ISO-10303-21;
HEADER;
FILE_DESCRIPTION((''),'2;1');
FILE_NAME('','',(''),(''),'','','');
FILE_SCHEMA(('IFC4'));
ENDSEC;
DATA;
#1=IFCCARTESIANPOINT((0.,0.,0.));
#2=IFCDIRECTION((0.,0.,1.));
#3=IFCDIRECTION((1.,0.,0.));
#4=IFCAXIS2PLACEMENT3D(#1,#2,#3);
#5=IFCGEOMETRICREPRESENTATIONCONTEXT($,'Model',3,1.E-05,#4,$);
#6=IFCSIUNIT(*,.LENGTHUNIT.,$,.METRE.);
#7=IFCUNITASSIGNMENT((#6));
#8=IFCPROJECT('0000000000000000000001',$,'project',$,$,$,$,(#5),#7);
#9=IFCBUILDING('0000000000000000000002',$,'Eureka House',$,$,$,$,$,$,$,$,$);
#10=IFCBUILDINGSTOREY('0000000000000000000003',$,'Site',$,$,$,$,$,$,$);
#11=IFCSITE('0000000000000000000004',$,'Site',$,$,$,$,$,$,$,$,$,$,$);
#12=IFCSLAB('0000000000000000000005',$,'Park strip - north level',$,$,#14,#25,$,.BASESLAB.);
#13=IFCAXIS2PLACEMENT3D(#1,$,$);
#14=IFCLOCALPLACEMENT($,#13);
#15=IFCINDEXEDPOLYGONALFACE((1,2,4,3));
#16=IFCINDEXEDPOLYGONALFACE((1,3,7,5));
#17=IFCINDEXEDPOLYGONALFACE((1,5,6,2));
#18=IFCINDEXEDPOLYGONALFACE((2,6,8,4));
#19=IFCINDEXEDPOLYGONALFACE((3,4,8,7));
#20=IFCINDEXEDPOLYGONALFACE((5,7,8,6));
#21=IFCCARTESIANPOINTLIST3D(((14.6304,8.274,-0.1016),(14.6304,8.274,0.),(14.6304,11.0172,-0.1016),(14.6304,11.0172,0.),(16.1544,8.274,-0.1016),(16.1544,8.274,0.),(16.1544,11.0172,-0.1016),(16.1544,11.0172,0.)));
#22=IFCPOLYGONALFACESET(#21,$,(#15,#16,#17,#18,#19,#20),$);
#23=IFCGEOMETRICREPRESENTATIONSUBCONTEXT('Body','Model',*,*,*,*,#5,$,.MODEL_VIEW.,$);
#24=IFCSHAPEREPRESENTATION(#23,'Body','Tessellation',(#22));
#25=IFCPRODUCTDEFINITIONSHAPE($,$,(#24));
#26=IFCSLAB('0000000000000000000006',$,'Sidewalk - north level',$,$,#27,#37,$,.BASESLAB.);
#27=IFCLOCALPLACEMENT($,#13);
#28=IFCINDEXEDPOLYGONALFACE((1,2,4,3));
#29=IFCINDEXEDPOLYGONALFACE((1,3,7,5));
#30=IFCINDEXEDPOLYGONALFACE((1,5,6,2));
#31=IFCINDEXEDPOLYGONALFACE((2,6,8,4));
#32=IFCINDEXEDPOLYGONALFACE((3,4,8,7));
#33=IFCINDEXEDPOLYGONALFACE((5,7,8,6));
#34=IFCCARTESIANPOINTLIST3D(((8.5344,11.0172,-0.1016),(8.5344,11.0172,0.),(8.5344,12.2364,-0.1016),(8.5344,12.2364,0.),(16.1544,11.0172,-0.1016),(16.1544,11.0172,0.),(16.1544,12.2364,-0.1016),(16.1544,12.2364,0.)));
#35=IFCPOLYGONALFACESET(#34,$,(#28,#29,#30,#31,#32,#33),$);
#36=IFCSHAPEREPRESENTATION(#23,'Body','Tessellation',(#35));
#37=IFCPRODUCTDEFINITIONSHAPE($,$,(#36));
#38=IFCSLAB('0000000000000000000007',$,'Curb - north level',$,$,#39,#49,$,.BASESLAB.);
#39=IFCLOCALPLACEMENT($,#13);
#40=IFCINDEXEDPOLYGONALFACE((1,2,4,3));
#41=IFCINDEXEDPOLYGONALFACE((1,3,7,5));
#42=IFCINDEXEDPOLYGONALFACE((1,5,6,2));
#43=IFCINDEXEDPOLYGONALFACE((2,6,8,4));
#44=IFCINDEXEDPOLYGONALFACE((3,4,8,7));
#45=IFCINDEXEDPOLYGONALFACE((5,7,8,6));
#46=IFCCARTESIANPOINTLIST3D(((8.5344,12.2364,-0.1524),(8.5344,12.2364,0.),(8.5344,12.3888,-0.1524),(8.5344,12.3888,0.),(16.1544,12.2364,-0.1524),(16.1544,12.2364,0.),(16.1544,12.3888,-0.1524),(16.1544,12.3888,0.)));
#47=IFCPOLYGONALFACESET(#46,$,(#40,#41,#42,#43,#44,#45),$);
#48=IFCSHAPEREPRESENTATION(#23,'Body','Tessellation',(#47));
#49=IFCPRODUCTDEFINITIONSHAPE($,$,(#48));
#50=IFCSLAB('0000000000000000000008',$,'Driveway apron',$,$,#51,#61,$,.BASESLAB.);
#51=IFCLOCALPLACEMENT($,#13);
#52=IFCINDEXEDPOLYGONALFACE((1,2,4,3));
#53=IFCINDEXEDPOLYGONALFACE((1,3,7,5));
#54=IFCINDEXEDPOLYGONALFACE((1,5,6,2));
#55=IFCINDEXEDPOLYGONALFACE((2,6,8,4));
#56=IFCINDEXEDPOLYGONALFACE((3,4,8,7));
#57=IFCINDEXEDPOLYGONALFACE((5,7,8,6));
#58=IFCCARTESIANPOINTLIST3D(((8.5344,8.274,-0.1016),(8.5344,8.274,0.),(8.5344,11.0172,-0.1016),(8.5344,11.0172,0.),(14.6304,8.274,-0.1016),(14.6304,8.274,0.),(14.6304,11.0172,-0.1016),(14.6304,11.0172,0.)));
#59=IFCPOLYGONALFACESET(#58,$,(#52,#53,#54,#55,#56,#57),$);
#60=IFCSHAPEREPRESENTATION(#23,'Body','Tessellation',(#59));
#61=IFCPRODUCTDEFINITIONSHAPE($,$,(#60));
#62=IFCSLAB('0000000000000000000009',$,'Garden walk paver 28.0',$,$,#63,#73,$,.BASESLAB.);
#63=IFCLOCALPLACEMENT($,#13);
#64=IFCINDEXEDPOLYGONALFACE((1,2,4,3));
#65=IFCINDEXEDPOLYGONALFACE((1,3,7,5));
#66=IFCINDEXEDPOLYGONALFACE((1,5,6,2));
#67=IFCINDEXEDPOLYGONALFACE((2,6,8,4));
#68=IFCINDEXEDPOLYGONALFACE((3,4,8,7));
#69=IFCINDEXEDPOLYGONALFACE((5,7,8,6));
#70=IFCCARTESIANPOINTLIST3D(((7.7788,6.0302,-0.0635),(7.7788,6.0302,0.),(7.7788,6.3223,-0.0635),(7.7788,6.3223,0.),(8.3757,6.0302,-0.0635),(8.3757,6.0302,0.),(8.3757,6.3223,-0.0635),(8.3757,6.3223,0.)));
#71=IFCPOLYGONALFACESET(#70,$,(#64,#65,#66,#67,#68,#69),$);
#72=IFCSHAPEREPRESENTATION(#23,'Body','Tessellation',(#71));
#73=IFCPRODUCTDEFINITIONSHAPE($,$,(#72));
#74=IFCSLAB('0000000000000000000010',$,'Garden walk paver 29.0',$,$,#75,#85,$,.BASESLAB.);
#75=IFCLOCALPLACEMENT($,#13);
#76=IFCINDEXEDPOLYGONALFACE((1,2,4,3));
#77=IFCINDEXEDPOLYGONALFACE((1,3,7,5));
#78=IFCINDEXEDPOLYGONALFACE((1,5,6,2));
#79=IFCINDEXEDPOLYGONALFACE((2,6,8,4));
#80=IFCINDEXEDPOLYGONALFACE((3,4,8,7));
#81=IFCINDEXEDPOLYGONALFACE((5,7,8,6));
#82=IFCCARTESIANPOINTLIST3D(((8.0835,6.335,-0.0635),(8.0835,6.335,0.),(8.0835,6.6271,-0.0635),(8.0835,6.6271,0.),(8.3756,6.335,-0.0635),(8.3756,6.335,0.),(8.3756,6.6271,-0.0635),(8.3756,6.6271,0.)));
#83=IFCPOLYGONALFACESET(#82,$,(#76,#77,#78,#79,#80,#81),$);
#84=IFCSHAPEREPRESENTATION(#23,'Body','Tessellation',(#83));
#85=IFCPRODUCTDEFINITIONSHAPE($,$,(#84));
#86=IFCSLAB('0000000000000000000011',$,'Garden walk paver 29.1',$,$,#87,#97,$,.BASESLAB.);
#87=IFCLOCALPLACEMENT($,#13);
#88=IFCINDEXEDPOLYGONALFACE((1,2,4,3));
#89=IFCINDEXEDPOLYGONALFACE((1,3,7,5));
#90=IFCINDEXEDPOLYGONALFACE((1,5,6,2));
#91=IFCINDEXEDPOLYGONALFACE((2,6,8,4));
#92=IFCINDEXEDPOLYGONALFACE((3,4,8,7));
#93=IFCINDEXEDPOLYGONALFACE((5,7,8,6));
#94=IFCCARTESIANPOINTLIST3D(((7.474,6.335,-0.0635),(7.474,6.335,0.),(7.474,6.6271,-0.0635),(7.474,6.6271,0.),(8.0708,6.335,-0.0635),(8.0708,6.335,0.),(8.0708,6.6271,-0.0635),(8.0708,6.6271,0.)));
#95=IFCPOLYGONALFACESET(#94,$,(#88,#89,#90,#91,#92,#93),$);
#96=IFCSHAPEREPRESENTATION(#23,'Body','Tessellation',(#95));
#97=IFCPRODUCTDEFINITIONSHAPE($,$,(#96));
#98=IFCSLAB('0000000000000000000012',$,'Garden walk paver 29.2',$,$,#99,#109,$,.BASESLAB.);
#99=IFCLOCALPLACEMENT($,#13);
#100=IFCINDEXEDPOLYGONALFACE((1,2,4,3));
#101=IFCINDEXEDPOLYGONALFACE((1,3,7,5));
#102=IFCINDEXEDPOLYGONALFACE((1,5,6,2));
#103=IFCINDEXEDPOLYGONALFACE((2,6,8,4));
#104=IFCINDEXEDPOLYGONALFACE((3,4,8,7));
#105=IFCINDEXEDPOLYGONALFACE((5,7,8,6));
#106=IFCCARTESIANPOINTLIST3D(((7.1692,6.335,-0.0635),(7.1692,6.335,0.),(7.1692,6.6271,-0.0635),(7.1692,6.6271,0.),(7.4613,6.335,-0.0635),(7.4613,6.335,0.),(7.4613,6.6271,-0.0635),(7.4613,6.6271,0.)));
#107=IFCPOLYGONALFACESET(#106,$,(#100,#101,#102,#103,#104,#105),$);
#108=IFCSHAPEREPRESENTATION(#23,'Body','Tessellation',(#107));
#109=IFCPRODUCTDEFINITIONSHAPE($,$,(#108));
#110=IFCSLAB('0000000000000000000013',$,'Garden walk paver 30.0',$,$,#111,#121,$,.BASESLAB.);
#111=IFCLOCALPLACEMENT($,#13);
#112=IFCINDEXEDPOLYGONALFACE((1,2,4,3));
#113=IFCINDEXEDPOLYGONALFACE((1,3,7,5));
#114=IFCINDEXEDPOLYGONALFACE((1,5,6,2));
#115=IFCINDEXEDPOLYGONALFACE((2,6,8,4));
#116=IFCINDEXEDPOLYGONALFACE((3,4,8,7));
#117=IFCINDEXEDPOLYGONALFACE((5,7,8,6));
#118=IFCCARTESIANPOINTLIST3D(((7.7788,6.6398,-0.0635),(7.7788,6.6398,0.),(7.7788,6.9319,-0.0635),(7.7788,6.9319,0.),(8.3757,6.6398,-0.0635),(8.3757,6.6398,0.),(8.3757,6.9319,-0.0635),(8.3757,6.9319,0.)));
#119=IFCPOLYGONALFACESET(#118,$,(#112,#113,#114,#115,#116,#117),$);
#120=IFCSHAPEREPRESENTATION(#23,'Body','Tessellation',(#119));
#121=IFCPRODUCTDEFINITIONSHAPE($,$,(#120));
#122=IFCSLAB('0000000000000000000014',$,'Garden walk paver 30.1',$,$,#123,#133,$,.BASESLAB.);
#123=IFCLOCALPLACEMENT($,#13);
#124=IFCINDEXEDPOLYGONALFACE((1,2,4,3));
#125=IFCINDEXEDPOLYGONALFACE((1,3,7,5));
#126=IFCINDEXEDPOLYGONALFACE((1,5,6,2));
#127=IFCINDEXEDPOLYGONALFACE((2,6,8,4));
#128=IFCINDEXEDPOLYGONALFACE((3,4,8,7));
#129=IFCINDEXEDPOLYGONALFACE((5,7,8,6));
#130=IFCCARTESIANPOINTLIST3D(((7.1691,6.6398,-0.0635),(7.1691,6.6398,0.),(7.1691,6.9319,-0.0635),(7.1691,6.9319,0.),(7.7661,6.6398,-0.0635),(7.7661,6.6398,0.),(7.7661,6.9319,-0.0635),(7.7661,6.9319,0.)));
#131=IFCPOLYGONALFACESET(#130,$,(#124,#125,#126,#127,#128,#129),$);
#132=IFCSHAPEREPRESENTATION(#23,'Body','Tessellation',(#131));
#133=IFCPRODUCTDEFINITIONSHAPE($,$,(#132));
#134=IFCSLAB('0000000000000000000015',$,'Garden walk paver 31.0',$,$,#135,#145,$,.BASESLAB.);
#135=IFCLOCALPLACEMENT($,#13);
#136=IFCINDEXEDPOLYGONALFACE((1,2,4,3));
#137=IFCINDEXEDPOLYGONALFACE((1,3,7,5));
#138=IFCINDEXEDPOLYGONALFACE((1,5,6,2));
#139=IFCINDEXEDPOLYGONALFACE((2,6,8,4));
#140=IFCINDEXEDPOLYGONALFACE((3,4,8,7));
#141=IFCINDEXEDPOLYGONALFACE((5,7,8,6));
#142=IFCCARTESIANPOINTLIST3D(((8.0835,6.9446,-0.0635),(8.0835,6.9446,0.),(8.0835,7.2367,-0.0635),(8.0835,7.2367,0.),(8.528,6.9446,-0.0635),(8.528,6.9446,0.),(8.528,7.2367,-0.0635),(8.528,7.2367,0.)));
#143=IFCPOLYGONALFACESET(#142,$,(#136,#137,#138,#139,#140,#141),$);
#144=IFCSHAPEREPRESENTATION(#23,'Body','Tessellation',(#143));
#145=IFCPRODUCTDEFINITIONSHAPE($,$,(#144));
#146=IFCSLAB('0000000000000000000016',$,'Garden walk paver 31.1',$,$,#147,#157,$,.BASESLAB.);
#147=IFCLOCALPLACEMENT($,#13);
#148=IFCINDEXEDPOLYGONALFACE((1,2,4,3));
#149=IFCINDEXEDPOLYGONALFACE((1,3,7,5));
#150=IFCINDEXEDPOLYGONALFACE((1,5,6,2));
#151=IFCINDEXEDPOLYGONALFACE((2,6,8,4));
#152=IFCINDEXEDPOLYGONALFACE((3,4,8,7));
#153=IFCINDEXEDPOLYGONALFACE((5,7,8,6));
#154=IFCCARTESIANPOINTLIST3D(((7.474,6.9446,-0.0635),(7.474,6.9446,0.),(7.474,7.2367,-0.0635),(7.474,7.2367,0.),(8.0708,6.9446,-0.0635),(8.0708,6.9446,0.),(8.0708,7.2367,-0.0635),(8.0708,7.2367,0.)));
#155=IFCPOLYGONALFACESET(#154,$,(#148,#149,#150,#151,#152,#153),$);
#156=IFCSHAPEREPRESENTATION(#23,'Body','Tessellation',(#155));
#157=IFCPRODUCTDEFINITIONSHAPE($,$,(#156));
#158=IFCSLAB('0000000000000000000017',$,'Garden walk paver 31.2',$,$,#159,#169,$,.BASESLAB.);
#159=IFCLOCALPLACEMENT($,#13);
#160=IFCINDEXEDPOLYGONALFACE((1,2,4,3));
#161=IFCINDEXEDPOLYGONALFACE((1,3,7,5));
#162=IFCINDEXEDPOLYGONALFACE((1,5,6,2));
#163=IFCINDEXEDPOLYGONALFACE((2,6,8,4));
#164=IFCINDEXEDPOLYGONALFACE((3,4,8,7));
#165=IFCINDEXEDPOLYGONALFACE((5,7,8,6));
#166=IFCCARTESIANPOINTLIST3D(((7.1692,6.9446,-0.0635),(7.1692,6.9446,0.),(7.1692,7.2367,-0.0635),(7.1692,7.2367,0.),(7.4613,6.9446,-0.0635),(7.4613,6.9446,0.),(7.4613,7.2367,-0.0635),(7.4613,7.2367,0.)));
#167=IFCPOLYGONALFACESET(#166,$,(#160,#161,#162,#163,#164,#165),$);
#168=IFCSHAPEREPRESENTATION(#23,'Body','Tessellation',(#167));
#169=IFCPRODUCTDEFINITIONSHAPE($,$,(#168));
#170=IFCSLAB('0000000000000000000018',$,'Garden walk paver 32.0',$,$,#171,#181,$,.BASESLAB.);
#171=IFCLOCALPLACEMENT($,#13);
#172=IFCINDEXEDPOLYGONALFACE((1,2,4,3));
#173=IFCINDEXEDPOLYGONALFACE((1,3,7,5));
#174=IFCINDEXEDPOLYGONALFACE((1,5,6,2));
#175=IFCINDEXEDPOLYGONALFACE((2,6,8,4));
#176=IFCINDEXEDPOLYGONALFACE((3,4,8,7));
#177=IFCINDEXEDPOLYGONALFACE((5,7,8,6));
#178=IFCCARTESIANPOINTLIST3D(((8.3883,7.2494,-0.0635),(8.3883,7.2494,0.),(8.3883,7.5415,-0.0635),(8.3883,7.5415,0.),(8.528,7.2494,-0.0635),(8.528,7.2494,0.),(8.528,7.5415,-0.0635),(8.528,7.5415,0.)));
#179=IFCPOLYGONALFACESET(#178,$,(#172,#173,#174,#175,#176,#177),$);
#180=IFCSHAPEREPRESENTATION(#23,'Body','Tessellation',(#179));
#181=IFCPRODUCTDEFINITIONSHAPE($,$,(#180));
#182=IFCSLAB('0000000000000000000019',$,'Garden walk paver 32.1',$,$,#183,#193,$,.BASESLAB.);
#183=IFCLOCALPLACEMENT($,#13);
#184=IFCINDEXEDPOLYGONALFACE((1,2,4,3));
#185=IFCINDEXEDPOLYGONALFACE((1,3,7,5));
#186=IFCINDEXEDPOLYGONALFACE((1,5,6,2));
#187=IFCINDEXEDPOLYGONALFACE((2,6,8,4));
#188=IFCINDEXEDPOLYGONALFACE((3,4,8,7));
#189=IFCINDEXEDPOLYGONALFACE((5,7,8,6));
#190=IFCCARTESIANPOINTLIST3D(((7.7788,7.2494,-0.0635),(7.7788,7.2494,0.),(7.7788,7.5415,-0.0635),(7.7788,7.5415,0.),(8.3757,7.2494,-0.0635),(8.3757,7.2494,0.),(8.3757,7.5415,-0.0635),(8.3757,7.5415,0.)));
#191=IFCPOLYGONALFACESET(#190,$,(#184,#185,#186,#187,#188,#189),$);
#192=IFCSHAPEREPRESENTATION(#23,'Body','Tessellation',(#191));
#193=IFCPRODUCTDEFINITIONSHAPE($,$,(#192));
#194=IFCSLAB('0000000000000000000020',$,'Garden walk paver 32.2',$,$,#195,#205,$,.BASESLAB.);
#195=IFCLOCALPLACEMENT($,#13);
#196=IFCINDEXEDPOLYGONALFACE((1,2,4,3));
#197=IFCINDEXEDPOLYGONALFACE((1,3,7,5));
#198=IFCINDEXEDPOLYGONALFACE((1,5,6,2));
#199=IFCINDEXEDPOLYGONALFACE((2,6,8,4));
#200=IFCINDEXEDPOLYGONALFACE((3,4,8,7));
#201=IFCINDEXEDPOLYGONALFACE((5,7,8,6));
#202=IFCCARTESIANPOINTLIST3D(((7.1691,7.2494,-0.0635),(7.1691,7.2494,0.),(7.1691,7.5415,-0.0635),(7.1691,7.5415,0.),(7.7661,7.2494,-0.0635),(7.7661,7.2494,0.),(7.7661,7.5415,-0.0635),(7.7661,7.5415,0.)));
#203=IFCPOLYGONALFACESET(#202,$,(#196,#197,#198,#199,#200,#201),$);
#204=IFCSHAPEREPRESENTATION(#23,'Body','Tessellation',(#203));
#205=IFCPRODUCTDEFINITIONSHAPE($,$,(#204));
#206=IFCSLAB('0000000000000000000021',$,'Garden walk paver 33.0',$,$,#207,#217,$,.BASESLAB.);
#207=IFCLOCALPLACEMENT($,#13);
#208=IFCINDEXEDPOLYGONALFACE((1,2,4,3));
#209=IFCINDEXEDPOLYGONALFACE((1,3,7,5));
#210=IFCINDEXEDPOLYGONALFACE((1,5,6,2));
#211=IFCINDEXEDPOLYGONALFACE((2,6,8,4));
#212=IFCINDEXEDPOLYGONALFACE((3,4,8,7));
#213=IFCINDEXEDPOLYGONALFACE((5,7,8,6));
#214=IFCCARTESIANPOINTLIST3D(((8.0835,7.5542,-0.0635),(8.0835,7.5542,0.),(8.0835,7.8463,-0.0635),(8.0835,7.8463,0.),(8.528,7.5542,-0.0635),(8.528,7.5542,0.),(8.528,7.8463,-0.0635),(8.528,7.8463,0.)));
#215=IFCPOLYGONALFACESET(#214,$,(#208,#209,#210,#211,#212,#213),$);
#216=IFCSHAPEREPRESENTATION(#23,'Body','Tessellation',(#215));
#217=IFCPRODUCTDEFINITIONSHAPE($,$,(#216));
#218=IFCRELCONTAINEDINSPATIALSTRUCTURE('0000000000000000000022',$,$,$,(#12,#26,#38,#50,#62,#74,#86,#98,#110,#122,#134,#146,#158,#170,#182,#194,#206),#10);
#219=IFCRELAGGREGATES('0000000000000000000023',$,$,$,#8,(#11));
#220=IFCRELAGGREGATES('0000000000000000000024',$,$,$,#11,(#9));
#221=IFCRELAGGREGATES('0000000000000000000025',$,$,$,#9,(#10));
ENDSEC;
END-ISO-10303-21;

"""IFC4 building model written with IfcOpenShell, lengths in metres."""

from ifc_helpers import new_model, si_unit, frame, origin, origin_with_axes, origin_2d, place, context, subcontext, project, spatial, rectangle, extrude, element, save


model = new_model("IFC4")

# Units and contexts
model_context = context("Model", 3, precision=1e-05, world=origin_with_axes())
body_context = subcontext(model_context, "Body", "Model", "MODEL_VIEW")
ifc_project = project(units=[si_unit("LENGTHUNIT", "METRE")], contexts=[model_context])

# Site, building, storey
site = spatial("IfcSite", under=ifc_project, Name="Site")
building = spatial("IfcBuilding", under=site, Name="Eureka House")
storey = spatial("IfcBuildingStorey", under=building, Name="Site")

# Slabs
slab_1_placement = place(None, frame((15.3924, 9.6456, -0.1016), z_axis=(0.0, 0.0, 1.0), x_axis=(1.0, 0.0, 0.0)))
element("IfcSlab", 1, at=slab_1_placement, inside=storey, Name="Park strip - north level", PredefinedType="BASESLAB", context=body_context, shape_type="SweptSolid", body=[
    extrude(rectangle(XDim=1.524, YDim=2.7432, at=origin_2d()), origin(), (0.0, 0.0, 1.0), 0.1016),
])
slab_2_placement = place(None, frame((12.3444, 11.6268, -0.1016), z_axis=(0.0, 0.0, 1.0), x_axis=(1.0, 0.0, 0.0)))
element("IfcSlab", 2, at=slab_2_placement, inside=storey, Name="Sidewalk - north level", PredefinedType="BASESLAB", context=body_context, shape_type="SweptSolid", body=[
    extrude(rectangle(XDim=7.62, YDim=1.2192, at=origin_2d()), origin(), (0.0, 0.0, 1.0), 0.1016),
])
slab_3_placement = place(None, frame((12.3444, 12.3126, -0.1524), z_axis=(0.0, 0.0, 1.0), x_axis=(1.0, 0.0, 0.0)))
element("IfcSlab", 3, at=slab_3_placement, inside=storey, Name="Curb - north level", PredefinedType="BASESLAB", context=body_context, shape_type="SweptSolid", body=[
    extrude(rectangle(XDim=7.62, YDim=0.1524, at=origin_2d()), origin(), (0.0, 0.0, 1.0), 0.1524),
])
slab_4_placement = place(None, frame((11.5824, 9.6456, -0.1016), z_axis=(0.0, 0.0, 1.0), x_axis=(1.0, 0.0, 0.0)))
element("IfcSlab", 4, at=slab_4_placement, inside=storey, Name="Driveway apron", PredefinedType="BASESLAB", context=body_context, shape_type="SweptSolid", body=[
    extrude(rectangle(XDim=6.096, YDim=2.7432, at=origin_2d()), origin(), (0.0, 0.0, 1.0), 0.1016),
])
slab_5_placement = place(None, frame((8.0772, 6.1763, -0.0635), z_axis=(0.0, 0.0, 1.0), x_axis=(1.0, 0.0, 0.0)))
element("IfcSlab", 5, at=slab_5_placement, inside=storey, Name="Garden walk paver 28.0", PredefinedType="BASESLAB", context=body_context, shape_type="SweptSolid", body=[
    extrude(rectangle(XDim=0.5969, YDim=0.2921, at=origin_2d()), origin(), (0.0, 0.0, 1.0), 0.0635),
])
slab_6_placement = place(None, frame((8.2296, 6.4811, -0.0635), z_axis=(0.0, 0.0, 1.0), x_axis=(1.0, 0.0, 0.0)))
element("IfcSlab", 6, at=slab_6_placement, inside=storey, Name="Garden walk paver 29.0", PredefinedType="BASESLAB", context=body_context, shape_type="SweptSolid", body=[
    extrude(rectangle(XDim=0.2921, YDim=0.2921, at=origin_2d()), origin(), (0.0, 0.0, 1.0), 0.0635),
])
slab_7_placement = place(None, frame((7.7724, 6.4811, -0.0635), z_axis=(0.0, 0.0, 1.0), x_axis=(1.0, 0.0, 0.0)))
element("IfcSlab", 7, at=slab_7_placement, inside=storey, Name="Garden walk paver 29.1", PredefinedType="BASESLAB", context=body_context, shape_type="SweptSolid", body=[
    extrude(rectangle(XDim=0.5969, YDim=0.2921, at=origin_2d()), origin(), (0.0, 0.0, 1.0), 0.0635),
])
slab_8_placement = place(None, frame((7.3152, 6.4811, -0.0635), z_axis=(0.0, 0.0, 1.0), x_axis=(1.0, 0.0, 0.0)))
element("IfcSlab", 8, at=slab_8_placement, inside=storey, Name="Garden walk paver 29.2", PredefinedType="BASESLAB", context=body_context, shape_type="SweptSolid", body=[
    extrude(rectangle(XDim=0.2921, YDim=0.2921, at=origin_2d()), origin(), (0.0, 0.0, 1.0), 0.0635),
])
for number, where, z_axis, x_axis, name in (
    (9, (8.0772, 6.7859, -0.0635), (0.0, 0.0, 1.0), (1.0, 0.0, 0.0), "Garden walk paver 30.0"),
    (10, (7.4676, 6.7859, -0.0635), (0.0, 0.0, 1.0), (1.0, 0.0, 0.0), "Garden walk paver 30.1"),
):
    element("IfcSlab", number, at=place(None, frame(where, z_axis=z_axis, x_axis=x_axis)), inside=storey, Name=name, PredefinedType="BASESLAB", context=body_context, shape_type="SweptSolid", body=[
        extrude(rectangle(XDim=0.5969, YDim=0.2921, at=origin_2d()), origin(), (0.0, 0.0, 1.0), 0.0635),
    ])
slab_9_placement = place(None, frame((8.3058, 7.0907, -0.0635), z_axis=(0.0, 0.0, 1.0), x_axis=(1.0, 0.0, 0.0)))
element("IfcSlab", 11, at=slab_9_placement, inside=storey, Name="Garden walk paver 31.0", PredefinedType="BASESLAB", context=body_context, shape_type="SweptSolid", body=[
    extrude(rectangle(XDim=0.4445, YDim=0.2921, at=origin_2d()), origin(), (0.0, 0.0, 1.0), 0.0635),
])
slab_10_placement = place(None, frame((7.7724, 7.0907, -0.0635), z_axis=(0.0, 0.0, 1.0), x_axis=(1.0, 0.0, 0.0)))
element("IfcSlab", 12, at=slab_10_placement, inside=storey, Name="Garden walk paver 31.1", PredefinedType="BASESLAB", context=body_context, shape_type="SweptSolid", body=[
    extrude(rectangle(XDim=0.5969, YDim=0.2921, at=origin_2d()), origin(), (0.0, 0.0, 1.0), 0.0635),
])
slab_11_placement = place(None, frame((7.3152, 7.0907, -0.0635), z_axis=(0.0, 0.0, 1.0), x_axis=(1.0, 0.0, 0.0)))
element("IfcSlab", 13, at=slab_11_placement, inside=storey, Name="Garden walk paver 31.2", PredefinedType="BASESLAB", context=body_context, shape_type="SweptSolid", body=[
    extrude(rectangle(XDim=0.2921, YDim=0.2921, at=origin_2d()), origin(), (0.0, 0.0, 1.0), 0.0635),
])
slab_12_placement = place(None, frame((8.4582, 7.3955, -0.0635), z_axis=(0.0, 0.0, 1.0), x_axis=(1.0, 0.0, 0.0)))
element("IfcSlab", 14, at=slab_12_placement, inside=storey, Name="Garden walk paver 32.0", PredefinedType="BASESLAB", context=body_context, shape_type="SweptSolid", body=[
    extrude(rectangle(XDim=0.1397, YDim=0.2921, at=origin_2d()), origin(), (0.0, 0.0, 1.0), 0.0635),
])
for number, where, z_axis, x_axis, name in (
    (15, (8.0772, 7.3955, -0.0635), (0.0, 0.0, 1.0), (1.0, 0.0, 0.0), "Garden walk paver 32.1"),
    (16, (7.4676, 7.3955, -0.0635), (0.0, 0.0, 1.0), (1.0, 0.0, 0.0), "Garden walk paver 32.2"),
):
    element("IfcSlab", number, at=place(None, frame(where, z_axis=z_axis, x_axis=x_axis)), inside=storey, Name=name, PredefinedType="BASESLAB", context=body_context, shape_type="SweptSolid", body=[
        extrude(rectangle(XDim=0.5969, YDim=0.2921, at=origin_2d()), origin(), (0.0, 0.0, 1.0), 0.0635),
    ])
slab_13_placement = place(None, frame((8.3058, 7.7003, -0.0635), z_axis=(0.0, 0.0, 1.0), x_axis=(1.0, 0.0, 0.0)))
element("IfcSlab", 17, at=slab_13_placement, inside=storey, Name="Garden walk paver 33.0", PredefinedType="BASESLAB", context=body_context, shape_type="SweptSolid", body=[
    extrude(rectangle(XDim=0.4445, YDim=0.2921, at=origin_2d()), origin(), (0.0, 0.0, 1.0), 0.0635),
])

save(model, "model.ifc")
